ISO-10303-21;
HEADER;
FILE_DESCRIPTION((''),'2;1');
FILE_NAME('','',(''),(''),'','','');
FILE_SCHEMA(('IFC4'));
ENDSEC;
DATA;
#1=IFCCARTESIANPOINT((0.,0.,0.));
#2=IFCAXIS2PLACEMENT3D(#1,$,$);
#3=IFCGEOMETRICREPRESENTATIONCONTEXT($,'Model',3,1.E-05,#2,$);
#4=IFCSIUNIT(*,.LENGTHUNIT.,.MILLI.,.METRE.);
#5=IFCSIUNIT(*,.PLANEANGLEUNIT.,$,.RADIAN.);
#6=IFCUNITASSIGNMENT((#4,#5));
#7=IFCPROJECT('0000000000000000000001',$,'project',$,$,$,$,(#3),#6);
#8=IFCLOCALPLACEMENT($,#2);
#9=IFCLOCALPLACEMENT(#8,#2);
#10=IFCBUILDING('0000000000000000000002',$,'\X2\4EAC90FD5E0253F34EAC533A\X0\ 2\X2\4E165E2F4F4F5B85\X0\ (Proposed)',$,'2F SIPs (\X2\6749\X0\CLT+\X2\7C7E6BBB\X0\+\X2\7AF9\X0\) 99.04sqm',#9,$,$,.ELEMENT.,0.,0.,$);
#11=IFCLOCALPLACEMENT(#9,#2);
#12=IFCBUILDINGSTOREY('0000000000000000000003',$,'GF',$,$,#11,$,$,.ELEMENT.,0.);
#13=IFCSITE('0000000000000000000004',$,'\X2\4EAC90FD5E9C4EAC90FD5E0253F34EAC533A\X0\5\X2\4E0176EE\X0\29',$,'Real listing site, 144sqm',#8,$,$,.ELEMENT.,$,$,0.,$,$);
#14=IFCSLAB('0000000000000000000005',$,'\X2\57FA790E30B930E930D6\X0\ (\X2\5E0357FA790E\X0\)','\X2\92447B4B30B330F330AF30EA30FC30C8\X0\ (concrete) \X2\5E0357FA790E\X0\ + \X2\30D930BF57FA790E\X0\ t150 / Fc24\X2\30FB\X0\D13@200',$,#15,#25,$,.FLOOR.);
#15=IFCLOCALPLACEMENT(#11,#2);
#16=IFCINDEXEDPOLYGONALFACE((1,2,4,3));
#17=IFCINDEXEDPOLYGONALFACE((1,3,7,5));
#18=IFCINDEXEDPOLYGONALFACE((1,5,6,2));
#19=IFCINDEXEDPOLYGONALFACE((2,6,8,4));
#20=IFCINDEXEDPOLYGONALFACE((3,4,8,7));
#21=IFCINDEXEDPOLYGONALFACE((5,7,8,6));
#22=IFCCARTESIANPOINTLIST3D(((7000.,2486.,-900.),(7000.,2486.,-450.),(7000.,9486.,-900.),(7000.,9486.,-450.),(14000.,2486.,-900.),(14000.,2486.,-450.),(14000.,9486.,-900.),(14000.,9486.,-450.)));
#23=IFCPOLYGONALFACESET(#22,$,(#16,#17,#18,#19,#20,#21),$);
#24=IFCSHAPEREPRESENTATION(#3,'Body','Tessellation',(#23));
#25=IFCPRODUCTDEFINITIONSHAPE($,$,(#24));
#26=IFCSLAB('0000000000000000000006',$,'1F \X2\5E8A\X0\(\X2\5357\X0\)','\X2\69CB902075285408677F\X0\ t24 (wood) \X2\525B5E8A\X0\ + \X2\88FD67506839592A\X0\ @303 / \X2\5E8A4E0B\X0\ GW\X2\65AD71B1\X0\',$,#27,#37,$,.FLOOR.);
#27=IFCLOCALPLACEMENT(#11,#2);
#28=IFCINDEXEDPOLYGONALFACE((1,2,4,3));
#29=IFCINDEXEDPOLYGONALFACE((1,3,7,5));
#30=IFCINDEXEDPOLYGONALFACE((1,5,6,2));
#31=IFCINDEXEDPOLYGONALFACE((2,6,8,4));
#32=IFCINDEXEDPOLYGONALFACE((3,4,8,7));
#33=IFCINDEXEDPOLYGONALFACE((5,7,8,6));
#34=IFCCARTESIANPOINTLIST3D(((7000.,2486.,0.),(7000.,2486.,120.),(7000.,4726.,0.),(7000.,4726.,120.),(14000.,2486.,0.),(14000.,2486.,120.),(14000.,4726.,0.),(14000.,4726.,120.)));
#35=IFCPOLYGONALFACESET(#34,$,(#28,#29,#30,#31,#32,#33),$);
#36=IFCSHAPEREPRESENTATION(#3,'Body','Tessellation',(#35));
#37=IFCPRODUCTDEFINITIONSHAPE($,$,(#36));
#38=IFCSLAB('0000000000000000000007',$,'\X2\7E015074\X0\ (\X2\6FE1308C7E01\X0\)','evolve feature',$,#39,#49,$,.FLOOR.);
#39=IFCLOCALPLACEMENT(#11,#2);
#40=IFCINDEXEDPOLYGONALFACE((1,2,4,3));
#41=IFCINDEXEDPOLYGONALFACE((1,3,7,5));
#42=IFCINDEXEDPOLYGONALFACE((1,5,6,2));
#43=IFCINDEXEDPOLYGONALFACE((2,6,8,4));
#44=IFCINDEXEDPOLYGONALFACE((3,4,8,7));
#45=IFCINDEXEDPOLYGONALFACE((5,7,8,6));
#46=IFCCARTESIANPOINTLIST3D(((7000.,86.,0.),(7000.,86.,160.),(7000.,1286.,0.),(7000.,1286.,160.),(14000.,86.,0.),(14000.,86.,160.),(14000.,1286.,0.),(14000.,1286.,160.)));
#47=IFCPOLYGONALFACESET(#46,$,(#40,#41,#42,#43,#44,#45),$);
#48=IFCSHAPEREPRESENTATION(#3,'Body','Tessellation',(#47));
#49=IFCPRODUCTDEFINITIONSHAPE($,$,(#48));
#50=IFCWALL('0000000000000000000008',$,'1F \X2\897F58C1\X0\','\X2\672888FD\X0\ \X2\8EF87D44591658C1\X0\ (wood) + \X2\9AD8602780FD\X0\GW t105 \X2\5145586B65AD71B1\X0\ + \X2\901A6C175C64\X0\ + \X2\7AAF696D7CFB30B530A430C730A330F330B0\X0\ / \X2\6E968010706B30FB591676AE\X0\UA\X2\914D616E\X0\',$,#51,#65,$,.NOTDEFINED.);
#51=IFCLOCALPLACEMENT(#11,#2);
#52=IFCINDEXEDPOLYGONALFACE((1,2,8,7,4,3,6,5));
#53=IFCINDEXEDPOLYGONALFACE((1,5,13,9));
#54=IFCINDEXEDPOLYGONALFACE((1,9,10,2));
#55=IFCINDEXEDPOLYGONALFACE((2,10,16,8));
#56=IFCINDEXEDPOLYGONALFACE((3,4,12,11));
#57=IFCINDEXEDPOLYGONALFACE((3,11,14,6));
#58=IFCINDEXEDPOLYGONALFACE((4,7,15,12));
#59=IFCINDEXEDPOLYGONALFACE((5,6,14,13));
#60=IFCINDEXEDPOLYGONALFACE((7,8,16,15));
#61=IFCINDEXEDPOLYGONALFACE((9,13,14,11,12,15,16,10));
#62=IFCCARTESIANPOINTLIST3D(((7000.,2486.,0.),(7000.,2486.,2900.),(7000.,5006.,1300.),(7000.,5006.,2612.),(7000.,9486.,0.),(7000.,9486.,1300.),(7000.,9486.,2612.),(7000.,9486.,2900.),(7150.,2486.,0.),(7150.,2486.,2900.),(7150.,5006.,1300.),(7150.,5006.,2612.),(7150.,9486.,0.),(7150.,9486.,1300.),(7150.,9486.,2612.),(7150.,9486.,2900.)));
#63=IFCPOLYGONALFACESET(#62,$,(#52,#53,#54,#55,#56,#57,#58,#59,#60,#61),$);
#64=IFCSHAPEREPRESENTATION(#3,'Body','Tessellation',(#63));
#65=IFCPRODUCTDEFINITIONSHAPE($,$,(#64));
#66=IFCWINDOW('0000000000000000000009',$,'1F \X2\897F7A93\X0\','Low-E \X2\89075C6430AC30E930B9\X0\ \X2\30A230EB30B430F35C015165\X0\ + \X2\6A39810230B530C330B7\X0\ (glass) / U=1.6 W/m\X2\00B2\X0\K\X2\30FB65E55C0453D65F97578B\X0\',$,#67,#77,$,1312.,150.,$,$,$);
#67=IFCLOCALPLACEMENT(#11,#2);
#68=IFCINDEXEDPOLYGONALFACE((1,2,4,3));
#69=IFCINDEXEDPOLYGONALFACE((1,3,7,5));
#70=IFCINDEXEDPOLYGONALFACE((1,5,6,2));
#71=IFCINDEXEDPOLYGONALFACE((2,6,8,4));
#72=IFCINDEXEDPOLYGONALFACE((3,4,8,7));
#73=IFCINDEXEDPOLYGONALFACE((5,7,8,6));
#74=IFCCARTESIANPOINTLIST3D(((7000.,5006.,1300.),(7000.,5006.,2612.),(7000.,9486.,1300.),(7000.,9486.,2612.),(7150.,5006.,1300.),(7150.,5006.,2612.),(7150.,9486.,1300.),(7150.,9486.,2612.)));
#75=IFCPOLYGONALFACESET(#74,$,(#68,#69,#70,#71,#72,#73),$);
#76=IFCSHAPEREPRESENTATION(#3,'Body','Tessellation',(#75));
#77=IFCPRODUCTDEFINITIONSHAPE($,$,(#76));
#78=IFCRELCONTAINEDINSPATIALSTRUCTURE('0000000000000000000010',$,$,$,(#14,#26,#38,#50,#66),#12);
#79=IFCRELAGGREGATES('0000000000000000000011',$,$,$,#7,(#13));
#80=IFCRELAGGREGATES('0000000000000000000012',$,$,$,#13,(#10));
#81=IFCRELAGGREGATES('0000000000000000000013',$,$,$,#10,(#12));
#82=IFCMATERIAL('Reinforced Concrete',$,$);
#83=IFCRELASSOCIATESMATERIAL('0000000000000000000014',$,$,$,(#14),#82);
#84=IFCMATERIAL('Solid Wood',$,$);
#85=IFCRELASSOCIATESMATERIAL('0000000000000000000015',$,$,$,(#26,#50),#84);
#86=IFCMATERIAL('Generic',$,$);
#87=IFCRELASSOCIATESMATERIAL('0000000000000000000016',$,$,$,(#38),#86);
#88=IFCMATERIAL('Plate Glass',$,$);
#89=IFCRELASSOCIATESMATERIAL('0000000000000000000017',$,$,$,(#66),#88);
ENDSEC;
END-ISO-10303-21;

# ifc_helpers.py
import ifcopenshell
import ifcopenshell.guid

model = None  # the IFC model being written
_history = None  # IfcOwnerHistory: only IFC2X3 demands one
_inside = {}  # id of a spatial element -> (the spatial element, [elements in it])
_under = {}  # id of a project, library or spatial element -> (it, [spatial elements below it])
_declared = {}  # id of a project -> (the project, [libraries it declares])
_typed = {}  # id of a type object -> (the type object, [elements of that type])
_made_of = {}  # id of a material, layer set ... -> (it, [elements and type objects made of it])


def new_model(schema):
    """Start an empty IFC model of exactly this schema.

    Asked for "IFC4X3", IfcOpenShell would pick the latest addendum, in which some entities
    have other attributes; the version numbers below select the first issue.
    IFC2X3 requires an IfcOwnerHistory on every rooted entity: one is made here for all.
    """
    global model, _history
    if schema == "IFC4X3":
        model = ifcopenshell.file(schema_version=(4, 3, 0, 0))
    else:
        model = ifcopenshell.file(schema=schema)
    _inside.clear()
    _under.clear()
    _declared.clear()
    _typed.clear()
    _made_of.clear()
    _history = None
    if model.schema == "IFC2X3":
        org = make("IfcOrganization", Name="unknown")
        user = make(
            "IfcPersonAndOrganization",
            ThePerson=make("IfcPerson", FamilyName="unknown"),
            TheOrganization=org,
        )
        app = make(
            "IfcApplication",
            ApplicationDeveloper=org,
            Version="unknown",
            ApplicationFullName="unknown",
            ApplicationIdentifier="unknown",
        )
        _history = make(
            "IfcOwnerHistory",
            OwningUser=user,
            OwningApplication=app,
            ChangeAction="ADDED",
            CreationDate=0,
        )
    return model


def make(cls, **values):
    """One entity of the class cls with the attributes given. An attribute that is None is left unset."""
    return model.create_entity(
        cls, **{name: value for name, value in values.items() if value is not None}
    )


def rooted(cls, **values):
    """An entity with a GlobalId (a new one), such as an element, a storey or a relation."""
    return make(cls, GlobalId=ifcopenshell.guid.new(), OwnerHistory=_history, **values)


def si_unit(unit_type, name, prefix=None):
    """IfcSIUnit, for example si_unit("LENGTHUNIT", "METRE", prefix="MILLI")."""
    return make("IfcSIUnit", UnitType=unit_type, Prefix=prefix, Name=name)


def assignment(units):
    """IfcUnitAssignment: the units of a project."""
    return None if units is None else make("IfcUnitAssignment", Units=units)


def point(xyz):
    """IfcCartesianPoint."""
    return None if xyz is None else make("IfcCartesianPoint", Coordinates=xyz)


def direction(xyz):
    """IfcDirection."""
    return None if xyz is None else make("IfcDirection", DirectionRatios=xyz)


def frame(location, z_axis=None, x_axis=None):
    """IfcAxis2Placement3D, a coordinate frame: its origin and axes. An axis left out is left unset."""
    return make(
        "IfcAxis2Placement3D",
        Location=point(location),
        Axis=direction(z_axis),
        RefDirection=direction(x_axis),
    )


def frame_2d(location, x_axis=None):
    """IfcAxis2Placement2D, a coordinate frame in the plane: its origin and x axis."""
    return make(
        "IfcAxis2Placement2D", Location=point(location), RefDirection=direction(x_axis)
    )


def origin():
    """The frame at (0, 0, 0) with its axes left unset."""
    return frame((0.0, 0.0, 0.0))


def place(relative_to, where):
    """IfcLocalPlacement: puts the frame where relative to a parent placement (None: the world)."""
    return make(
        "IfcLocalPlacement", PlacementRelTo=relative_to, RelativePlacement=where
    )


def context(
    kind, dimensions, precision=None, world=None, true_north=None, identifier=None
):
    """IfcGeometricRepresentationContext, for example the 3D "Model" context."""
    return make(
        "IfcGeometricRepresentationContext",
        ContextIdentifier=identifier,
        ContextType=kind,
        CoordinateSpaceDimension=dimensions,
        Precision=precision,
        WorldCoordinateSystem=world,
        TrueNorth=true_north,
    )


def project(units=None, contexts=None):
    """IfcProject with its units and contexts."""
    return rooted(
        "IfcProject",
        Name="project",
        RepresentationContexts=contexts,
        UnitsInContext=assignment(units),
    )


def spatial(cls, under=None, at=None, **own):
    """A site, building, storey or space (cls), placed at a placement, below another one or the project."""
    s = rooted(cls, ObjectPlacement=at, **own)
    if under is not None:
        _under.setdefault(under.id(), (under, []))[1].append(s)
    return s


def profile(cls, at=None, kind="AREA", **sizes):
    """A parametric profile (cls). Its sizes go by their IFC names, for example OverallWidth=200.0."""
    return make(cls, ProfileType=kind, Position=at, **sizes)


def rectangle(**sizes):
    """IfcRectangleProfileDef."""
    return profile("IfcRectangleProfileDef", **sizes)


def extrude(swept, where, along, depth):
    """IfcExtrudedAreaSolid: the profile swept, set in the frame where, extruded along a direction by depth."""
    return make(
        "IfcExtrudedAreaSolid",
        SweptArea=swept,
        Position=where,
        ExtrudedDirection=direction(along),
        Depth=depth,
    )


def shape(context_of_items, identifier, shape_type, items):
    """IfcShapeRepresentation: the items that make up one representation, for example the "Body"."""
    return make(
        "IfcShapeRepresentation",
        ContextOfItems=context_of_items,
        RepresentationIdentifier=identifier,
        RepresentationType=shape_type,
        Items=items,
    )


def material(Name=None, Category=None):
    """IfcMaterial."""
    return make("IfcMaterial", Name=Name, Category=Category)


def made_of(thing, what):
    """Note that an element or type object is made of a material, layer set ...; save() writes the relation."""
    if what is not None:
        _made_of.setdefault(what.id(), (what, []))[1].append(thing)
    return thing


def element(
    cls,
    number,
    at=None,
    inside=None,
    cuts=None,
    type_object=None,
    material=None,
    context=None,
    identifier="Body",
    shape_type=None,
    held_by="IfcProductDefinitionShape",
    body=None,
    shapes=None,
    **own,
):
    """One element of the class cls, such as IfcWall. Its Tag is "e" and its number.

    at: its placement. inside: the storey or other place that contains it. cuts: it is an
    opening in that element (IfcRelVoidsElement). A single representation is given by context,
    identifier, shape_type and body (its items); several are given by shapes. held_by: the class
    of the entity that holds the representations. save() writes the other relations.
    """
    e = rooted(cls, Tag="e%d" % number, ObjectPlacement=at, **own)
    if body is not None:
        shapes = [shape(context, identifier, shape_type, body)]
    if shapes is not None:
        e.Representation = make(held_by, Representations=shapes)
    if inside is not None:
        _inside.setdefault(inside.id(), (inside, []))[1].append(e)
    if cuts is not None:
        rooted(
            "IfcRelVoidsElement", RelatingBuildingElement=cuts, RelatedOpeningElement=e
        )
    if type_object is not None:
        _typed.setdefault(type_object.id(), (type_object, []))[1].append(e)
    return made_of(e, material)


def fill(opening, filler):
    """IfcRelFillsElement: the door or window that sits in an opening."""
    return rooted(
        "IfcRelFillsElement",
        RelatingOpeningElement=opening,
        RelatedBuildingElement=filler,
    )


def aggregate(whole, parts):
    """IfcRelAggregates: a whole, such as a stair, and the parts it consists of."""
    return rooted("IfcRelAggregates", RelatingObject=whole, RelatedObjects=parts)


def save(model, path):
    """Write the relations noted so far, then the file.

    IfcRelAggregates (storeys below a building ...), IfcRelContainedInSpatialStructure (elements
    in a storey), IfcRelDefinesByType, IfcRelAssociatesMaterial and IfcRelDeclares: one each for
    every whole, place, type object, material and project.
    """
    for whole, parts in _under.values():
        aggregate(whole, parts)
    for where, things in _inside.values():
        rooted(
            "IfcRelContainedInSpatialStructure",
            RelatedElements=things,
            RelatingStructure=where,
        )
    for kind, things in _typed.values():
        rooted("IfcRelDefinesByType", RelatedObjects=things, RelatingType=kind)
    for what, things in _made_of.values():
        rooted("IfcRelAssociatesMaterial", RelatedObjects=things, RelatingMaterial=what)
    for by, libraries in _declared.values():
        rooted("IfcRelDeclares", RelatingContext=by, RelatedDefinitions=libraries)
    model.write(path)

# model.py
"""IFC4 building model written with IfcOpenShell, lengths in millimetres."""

from ifc_helpers import new_model, si_unit, frame, frame_2d, origin, place, context, project, spatial, rectangle, extrude, material, element, fill, save


model = new_model("IFC4")

# Units and contexts
model_context = context("Model", 3, precision=1e-05, world=origin())
ifc_project = project(units=[si_unit("LENGTHUNIT", "METRE", prefix="MILLI"), si_unit("PLANEANGLEUNIT", "RADIAN")], contexts=[model_context])

# Site, building, storey
site_placement = place(None, origin())
site = spatial("IfcSite", under=ifc_project, at=site_placement, Name="京都府京都市右京区5丁目29", ObjectType="Real listing site, 144sqm", CompositionType="ELEMENT", RefElevation=0.0)
building_placement = place(site_placement, origin())
building = spatial("IfcBuilding", under=site, at=building_placement, Name="京都市右京区 2世帯住宅 (Proposed)", ObjectType="2F SIPs (杉CLT+籾殻+竹) 99.04sqm", CompositionType="ELEMENT", ElevationOfRefHeight=0.0, ElevationOfTerrain=0.0)
storey_placement = place(building_placement, origin())
storey = spatial("IfcBuildingStorey", under=building, at=storey_placement, Name="GF", CompositionType="ELEMENT", Elevation=0.0)

# Slabs
ifc_material_1 = material(Name="Reinforced Concrete")
slab_1_placement = place(storey_placement, frame((3500.0, 1243.0, -450.0)))
element("IfcSlab", 1, at=slab_1_placement, inside=storey, material=ifc_material_1, Name="基礎スラブ (布基礎)", Description="鉄筋コンクリート (concrete) 布基礎 + ベタ基礎 t150 / Fc24・D13@200", PredefinedType="FLOOR", context=model_context, shape_type="SweptSolid", body=[
    extrude(rectangle(XDim=7000.0, YDim=7000.0, at=frame_2d((3500.0, 3500.0))), frame((3500.0, 1243.0, -450.0)), (0.0, 0.0, 1.0), 450.0),
])
ifc_material_2 = material(Name="Solid Wood")
slab_2_placement = place(storey_placement, frame((3500.0, 1243.0, 0.0)))
element("IfcSlab", 2, at=slab_2_placement, inside=storey, material=ifc_material_2, Name="1F 床(南)", Description="構造用合板 t24 (wood) 剛床 + 製材根太 @303 / 床下 GW断熱", PredefinedType="FLOOR", context=model_context, shape_type="SweptSolid", body=[
    extrude(rectangle(XDim=7000.0, YDim=2240.0, at=frame_2d((3500.0, 1120.0))), frame((3500.0, 1243.0, 0.0)), (0.0, 0.0, 1.0), 120.0),
])
ifc_material_3 = material(Name="Generic")
slab_3_placement = place(storey_placement, frame((3500.0, 43.0, 0.0)))
element("IfcSlab", 3, at=slab_3_placement, inside=storey, material=ifc_material_3, Name="縁側 (濡れ縁)", Description="evolve feature", PredefinedType="FLOOR", context=model_context, shape_type="SweptSolid", body=[
    extrude(rectangle(XDim=7000.0, YDim=1200.0, at=frame_2d((3500.0, 600.0))), frame((3500.0, 43.0, 0.0)), (0.0, 0.0, 1.0), 160.0),
])

# Shared definitions
ifc_material_4 = material(Name="Plate Glass")

# Wall, opening, window
wall_1_placement = place(storey_placement, frame((3500.0, 1243.0, 0.0)))
wall_1 = element("IfcWall", 4, at=wall_1_placement, inside=storey, material=ifc_material_2, Name="1F 西壁", Description="木製 軸組外壁 (wood) + 高性能GW t105 充填断熱 + 通気層 + 窯業系サイディング / 準耐火・外皮UA配慮", PredefinedType="NOTDEFINED", context=model_context, shape_type="SweptSolid", body=[
    extrude(rectangle(XDim=150.0, YDim=7000.0, at=frame_2d((75.0, 3500.0))), frame((3500.0, 1243.0, 0.0)), (0.0, 0.0, 1.0), 2900.0),
])
opening_1_placement = place(storey_placement, frame((3500.0, 2503.0, 650.0)))
opening_1 = element("IfcOpeningElement", 5, at=opening_1_placement, cuts=wall_1, PredefinedType="NOTDEFINED", context=model_context, shape_type="SweptSolid", body=[
    extrude(rectangle(XDim=150.0, YDim=4480.0, at=frame_2d((75.0, 2240.0))), frame((3500.0, 2503.0, 650.0)), (0.0, 0.0, 1.0), 1312.0),
])
window_1_placement = place(storey_placement, frame((3500.0, 2503.0, 650.0)))
window_1 = element("IfcWindow", 6, at=window_1_placement, inside=storey, material=ifc_material_4, Name="1F 西窓", Description="Low-E 複層ガラス アルゴン封入 + 樹脂サッシ (glass) / U=1.6 W/m²K・日射取得型", OverallHeight=1312.0, OverallWidth=150.0, context=model_context, shape_type="SweptSolid", body=[
    extrude(rectangle(XDim=150.0, YDim=4480.0, at=frame_2d((75.0, 2240.0))), frame((3500.0, 2503.0, 650.0)), (0.0, 0.0, 1.0), 1312.0),
])
fill(opening_1, window_1)

save(model, "model.ifc")
